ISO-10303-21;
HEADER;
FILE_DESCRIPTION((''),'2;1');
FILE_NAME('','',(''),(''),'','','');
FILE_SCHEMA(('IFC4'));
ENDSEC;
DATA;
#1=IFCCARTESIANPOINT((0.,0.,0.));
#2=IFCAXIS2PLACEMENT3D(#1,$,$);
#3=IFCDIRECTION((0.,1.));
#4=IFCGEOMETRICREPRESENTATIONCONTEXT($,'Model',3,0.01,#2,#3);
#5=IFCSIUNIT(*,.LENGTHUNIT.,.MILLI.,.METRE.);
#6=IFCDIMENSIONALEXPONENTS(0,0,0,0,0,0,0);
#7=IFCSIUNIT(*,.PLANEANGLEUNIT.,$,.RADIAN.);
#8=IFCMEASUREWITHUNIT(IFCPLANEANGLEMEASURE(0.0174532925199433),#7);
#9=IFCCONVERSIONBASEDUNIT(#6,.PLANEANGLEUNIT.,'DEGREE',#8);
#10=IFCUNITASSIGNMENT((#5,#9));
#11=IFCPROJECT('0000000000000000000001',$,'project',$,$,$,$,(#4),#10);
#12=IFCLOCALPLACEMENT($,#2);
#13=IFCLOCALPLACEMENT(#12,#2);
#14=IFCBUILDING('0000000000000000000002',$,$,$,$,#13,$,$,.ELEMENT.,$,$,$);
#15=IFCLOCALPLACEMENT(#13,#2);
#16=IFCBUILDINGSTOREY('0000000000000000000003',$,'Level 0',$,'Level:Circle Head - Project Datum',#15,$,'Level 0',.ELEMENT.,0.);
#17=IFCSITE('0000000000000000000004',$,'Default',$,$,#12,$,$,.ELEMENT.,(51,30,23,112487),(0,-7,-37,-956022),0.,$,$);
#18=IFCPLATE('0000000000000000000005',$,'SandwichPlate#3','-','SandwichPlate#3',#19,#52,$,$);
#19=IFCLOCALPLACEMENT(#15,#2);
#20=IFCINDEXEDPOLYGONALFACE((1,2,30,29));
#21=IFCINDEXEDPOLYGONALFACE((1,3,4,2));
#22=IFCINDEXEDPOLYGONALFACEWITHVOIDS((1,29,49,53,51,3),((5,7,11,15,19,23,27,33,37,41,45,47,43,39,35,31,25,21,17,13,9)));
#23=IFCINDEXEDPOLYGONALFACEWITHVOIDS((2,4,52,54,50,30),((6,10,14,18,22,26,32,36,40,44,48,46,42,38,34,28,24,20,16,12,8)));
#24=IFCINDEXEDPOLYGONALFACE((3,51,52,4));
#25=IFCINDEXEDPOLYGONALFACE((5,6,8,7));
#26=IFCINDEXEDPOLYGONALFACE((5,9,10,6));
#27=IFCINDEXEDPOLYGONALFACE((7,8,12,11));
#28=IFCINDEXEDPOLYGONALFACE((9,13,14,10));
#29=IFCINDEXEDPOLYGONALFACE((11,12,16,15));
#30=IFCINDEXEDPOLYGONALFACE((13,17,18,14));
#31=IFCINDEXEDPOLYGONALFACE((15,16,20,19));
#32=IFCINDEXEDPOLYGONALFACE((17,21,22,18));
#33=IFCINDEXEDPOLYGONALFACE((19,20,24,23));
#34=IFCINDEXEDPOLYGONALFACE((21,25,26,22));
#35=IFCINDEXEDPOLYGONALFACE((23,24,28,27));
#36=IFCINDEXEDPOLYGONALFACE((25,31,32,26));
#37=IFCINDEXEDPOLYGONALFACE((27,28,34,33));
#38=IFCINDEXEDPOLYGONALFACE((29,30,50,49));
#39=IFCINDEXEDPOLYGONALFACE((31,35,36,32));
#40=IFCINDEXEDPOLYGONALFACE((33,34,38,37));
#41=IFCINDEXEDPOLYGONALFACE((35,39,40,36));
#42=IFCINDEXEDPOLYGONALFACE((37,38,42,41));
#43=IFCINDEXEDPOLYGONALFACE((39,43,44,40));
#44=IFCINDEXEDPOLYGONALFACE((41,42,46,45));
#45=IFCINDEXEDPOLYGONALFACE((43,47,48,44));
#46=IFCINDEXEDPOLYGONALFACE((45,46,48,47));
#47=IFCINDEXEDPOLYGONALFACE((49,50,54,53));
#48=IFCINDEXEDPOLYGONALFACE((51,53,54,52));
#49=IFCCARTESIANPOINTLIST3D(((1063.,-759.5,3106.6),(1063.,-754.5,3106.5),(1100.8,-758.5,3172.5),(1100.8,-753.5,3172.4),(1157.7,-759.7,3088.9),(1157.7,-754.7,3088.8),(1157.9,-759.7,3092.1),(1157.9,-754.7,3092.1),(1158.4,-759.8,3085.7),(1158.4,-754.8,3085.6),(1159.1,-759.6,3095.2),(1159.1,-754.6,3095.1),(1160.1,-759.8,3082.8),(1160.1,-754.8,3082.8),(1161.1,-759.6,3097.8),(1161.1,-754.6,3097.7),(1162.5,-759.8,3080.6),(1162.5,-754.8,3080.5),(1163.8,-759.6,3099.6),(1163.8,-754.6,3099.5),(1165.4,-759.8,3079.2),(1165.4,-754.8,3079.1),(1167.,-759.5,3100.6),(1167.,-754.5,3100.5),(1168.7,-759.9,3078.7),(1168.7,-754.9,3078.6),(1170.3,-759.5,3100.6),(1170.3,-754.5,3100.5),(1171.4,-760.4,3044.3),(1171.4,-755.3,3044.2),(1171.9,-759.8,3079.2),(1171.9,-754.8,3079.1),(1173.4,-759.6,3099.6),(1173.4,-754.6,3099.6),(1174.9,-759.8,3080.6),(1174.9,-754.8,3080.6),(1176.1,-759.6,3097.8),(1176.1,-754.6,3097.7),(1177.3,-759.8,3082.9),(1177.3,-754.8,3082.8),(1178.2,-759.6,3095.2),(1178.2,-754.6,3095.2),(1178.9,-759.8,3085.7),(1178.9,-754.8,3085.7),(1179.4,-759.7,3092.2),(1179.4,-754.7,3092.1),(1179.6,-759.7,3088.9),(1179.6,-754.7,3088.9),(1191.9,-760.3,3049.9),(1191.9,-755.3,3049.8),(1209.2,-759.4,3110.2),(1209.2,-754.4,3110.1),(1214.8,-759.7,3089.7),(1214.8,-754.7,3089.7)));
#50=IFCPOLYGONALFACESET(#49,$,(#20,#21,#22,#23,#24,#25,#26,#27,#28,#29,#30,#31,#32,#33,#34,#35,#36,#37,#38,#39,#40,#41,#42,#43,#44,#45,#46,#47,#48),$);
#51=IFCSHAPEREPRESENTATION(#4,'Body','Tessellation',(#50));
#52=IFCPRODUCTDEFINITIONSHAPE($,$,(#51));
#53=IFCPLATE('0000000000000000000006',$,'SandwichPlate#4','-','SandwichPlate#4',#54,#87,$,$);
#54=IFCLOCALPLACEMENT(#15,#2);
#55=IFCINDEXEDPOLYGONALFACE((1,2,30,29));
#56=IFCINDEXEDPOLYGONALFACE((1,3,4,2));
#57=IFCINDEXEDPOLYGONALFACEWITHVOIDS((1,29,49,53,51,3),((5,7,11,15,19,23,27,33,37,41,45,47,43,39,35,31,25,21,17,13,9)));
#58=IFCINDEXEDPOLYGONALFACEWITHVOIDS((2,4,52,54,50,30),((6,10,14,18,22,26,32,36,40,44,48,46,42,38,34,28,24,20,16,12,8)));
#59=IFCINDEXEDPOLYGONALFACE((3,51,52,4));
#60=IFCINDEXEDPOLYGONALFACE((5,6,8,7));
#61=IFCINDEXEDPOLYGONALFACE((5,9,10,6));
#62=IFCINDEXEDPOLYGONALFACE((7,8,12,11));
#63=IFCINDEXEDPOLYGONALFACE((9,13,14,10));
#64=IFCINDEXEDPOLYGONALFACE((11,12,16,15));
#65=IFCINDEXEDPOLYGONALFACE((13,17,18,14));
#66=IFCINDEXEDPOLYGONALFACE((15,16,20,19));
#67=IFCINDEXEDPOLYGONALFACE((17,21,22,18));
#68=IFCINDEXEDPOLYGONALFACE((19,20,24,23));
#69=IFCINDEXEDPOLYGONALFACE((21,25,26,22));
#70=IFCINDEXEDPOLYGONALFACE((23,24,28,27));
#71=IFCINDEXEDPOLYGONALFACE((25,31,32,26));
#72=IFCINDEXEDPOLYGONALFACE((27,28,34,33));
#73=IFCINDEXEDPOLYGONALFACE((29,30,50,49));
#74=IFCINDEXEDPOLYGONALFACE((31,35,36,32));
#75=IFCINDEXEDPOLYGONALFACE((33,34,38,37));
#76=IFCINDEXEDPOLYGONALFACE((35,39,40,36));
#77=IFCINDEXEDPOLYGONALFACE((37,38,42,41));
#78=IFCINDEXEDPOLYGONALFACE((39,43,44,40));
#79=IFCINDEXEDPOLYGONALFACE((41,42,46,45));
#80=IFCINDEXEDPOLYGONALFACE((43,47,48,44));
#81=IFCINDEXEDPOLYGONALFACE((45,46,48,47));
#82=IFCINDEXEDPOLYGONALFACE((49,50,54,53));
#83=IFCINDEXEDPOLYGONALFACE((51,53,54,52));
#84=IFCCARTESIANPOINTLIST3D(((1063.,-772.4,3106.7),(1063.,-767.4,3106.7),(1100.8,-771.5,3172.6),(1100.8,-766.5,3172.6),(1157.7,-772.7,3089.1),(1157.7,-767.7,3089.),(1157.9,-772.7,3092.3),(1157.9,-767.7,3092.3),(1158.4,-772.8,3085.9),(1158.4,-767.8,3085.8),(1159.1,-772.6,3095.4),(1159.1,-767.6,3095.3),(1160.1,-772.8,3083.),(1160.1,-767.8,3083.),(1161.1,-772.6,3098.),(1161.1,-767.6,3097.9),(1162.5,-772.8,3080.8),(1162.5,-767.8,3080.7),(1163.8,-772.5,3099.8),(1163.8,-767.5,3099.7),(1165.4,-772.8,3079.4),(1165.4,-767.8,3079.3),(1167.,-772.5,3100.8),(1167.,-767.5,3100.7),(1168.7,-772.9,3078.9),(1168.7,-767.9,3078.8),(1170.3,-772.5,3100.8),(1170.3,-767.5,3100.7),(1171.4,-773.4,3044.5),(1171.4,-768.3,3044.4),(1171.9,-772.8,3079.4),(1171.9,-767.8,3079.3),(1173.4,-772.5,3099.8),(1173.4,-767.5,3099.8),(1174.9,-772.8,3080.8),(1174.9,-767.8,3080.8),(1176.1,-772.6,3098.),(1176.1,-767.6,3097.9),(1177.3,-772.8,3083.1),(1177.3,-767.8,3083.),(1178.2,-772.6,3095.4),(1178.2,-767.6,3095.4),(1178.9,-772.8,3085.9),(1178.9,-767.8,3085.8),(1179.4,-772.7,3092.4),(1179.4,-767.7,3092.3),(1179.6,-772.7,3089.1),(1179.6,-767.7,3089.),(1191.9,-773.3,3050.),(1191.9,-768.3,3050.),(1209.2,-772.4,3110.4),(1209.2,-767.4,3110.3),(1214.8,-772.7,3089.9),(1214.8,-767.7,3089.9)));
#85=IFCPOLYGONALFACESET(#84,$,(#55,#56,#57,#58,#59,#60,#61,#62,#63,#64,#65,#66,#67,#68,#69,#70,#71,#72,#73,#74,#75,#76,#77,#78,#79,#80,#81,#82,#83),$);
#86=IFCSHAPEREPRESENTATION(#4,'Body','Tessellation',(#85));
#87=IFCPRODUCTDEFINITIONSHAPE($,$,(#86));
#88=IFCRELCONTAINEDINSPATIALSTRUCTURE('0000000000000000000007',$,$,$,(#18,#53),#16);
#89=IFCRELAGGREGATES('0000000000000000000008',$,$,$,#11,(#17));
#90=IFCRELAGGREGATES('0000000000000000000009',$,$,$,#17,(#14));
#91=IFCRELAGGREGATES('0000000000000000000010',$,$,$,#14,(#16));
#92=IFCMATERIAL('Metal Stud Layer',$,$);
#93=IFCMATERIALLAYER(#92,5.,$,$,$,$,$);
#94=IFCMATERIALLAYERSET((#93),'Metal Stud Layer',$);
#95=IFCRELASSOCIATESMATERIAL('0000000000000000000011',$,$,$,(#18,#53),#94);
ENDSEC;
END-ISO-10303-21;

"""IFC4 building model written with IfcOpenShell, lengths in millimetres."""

from ifc_helpers import new_model, entity, si_unit, converted_unit, direction, frame, origin, origin_with_axes, origin_2d_with_axis, place, context, project, spatial, polyline, circle, outline, extrude, material, layer, layer_set, element, save


model = new_model("IFC4")

# Units and contexts
model_context_1 = context("Model", 3, precision=0.01, world=origin(), true_north=direction((0.0, 1.0)))
ifc_project = project(units=[si_unit("LENGTHUNIT", "METRE", prefix="MILLI"), converted_unit("PLANEANGLEUNIT", "DEGREE", entity("IfcPlaneAngleMeasure", 0.0174532925199433), si_unit("PLANEANGLEUNIT", "RADIAN"), dimensions=[0, 0, 0, 0, 0, 0, 0])], contexts=[model_context_1])

# Site, building, storey
site_placement = place(None, origin())
site = spatial("IfcSite", under=ifc_project, at=site_placement, Name="Default", CompositionType="ELEMENT", RefLatitude=(51, 30, 23, 112487), RefLongitude=(0, -7, -37, -956022), RefElevation=0.0)
building_placement = place(site_placement, origin())
building = spatial("IfcBuilding", under=site, at=building_placement, CompositionType="ELEMENT")
storey_placement = place(building_placement, origin())
storey = spatial("IfcBuildingStorey", under=building, at=storey_placement, Name="Level 0", ObjectType="Level:Circle Head - Project Datum", LongName="Level 0", CompositionType="ELEMENT", Elevation=0.0)

# Plates, openings
ifc_material_1 = material(Name="Metal Stud Layer")
ifc_layer_1 = layer(ifc_material_1, 5.0)
ifc_layer_set_1 = layer_set([ifc_layer_1], Name="Metal Stud Layer")
plate_1_placement = place(storey_placement, frame((1184.4, -755.5, 3036.8), z_axis=(0.0, -0.999896, 0.014432), x_axis=(0.497964, 0.012516, 0.867107)))
plate_1 = element("IfcPlate", 1, at=plate_1_placement, inside=storey, material=ifc_layer_set_1, Name="SandwichPlate#3", Description="-", ObjectType="SandwichPlate#3", context=model_context_1, shape_type="SweptSolid", body=[
    extrude(outline(polyline([(0.0, 0.0), (76.0, 0.0), (76.0, 140.0), (0.0, 140.0), (0.0, 0.0)])), origin_with_axes(), (0.0, 0.0, 1.0), 5.0),
])
opening_1_placement = place(plate_1_placement, frame((0.0, 0.0, 0.0), z_axis=(0.0, 0.0, 1.0), x_axis=(1.0, 0.0, 0.0)))
element("IfcOpeningElement", 2, at=opening_1_placement, cuts=plate_1, ObjectType="Opening", context=model_context_1, shape_type="SweptSolid", body=[
    extrude(outline(polyline([(0.0, 0.0), (15.0, 0.0), (0.0, 15.0), (0.0, 0.0)])), origin(), (0.0, 0.0, 1.0), 5.0),
])
opening_2_placement = place(plate_1_placement, frame((0.0, 0.0, 0.0), z_axis=(0.0, 0.0, 1.0), x_axis=(1.0, 0.0, 0.0)))
element("IfcOpeningElement", 3, at=opening_2_placement, cuts=plate_1, ObjectType="Opening", context=model_context_1, shape_type="SweptSolid", body=[
    extrude(outline(polyline([(76.0, 0.0), (76.0, 15.0), (61.0, 0.0), (76.0, 0.0)])), origin(), (0.0, 0.0, 1.0), 5.0),
])
opening_3_placement = place(plate_1_placement, frame((38.0, 40.0, -0.5), z_axis=(0.0, 0.0, 1.0), x_axis=(0.0, 1.0, 0.0)))
element("IfcOpeningElement", 4, at=opening_3_placement, cuts=plate_1, ObjectType="Opening", context=model_context_1, shape_type="SweptSolid", body=[
    extrude(circle(Radius=11.0, at=origin_2d_with_axis()), origin(), (0.0, 0.0, 1.0), 6.0),
])
plate_2_placement = place(storey_placement, frame((1184.4, -768.5, 3037.0), z_axis=(0.0, -0.999896, 0.014432), x_axis=(0.497964, 0.012516, 0.867107)))
plate_2 = element("IfcPlate", 5, at=plate_2_placement, inside=storey, material=ifc_layer_set_1, Name="SandwichPlate#4", Description="-", ObjectType="SandwichPlate#4", context=model_context_1, shape_type="SweptSolid", body=[
    extrude(outline(polyline([(0.0, 0.0), (76.0, 0.0), (76.0, 140.0), (0.0, 140.0), (0.0, 0.0)])), origin_with_axes(), (0.0, 0.0, 1.0), 5.0),
])
opening_4_placement = place(plate_2_placement, frame((0.0, 0.0, 0.0), z_axis=(0.0, 0.0, 1.0), x_axis=(1.0, 0.0, 0.0)))
element("IfcOpeningElement", 6, at=opening_4_placement, cuts=plate_2, ObjectType="Opening", context=model_context_1, shape_type="SweptSolid", body=[
    extrude(outline(polyline([(0.0, 0.0), (15.0, 0.0), (0.0, 15.0), (0.0, 0.0)])), origin(), (0.0, 0.0, 1.0), 5.0),
])
opening_5_placement = place(plate_2_placement, frame((0.0, 0.0, 0.0), z_axis=(0.0, 0.0, 1.0), x_axis=(1.0, 0.0, 0.0)))
element("IfcOpeningElement", 7, at=opening_5_placement, cuts=plate_2, ObjectType="Opening", context=model_context_1, shape_type="SweptSolid", body=[
    extrude(outline(polyline([(76.0, 0.0), (76.0, 15.0), (61.0, 0.0), (76.0, 0.0)])), origin(), (0.0, 0.0, 1.0), 5.0),
])
opening_6_placement = place(plate_2_placement, frame((38.0, 40.0, -0.5), z_axis=(0.0, 0.0, 1.0), x_axis=(0.0, 1.0, 0.0)))
element("IfcOpeningElement", 8, at=opening_6_placement, cuts=plate_2, ObjectType="Opening", context=model_context_1, shape_type="SweptSolid", body=[
    extrude(circle(Radius=11.0, at=origin_2d_with_axis()), origin(), (0.0, 0.0, 1.0), 6.0),
])

save(model, "model.ifc")
